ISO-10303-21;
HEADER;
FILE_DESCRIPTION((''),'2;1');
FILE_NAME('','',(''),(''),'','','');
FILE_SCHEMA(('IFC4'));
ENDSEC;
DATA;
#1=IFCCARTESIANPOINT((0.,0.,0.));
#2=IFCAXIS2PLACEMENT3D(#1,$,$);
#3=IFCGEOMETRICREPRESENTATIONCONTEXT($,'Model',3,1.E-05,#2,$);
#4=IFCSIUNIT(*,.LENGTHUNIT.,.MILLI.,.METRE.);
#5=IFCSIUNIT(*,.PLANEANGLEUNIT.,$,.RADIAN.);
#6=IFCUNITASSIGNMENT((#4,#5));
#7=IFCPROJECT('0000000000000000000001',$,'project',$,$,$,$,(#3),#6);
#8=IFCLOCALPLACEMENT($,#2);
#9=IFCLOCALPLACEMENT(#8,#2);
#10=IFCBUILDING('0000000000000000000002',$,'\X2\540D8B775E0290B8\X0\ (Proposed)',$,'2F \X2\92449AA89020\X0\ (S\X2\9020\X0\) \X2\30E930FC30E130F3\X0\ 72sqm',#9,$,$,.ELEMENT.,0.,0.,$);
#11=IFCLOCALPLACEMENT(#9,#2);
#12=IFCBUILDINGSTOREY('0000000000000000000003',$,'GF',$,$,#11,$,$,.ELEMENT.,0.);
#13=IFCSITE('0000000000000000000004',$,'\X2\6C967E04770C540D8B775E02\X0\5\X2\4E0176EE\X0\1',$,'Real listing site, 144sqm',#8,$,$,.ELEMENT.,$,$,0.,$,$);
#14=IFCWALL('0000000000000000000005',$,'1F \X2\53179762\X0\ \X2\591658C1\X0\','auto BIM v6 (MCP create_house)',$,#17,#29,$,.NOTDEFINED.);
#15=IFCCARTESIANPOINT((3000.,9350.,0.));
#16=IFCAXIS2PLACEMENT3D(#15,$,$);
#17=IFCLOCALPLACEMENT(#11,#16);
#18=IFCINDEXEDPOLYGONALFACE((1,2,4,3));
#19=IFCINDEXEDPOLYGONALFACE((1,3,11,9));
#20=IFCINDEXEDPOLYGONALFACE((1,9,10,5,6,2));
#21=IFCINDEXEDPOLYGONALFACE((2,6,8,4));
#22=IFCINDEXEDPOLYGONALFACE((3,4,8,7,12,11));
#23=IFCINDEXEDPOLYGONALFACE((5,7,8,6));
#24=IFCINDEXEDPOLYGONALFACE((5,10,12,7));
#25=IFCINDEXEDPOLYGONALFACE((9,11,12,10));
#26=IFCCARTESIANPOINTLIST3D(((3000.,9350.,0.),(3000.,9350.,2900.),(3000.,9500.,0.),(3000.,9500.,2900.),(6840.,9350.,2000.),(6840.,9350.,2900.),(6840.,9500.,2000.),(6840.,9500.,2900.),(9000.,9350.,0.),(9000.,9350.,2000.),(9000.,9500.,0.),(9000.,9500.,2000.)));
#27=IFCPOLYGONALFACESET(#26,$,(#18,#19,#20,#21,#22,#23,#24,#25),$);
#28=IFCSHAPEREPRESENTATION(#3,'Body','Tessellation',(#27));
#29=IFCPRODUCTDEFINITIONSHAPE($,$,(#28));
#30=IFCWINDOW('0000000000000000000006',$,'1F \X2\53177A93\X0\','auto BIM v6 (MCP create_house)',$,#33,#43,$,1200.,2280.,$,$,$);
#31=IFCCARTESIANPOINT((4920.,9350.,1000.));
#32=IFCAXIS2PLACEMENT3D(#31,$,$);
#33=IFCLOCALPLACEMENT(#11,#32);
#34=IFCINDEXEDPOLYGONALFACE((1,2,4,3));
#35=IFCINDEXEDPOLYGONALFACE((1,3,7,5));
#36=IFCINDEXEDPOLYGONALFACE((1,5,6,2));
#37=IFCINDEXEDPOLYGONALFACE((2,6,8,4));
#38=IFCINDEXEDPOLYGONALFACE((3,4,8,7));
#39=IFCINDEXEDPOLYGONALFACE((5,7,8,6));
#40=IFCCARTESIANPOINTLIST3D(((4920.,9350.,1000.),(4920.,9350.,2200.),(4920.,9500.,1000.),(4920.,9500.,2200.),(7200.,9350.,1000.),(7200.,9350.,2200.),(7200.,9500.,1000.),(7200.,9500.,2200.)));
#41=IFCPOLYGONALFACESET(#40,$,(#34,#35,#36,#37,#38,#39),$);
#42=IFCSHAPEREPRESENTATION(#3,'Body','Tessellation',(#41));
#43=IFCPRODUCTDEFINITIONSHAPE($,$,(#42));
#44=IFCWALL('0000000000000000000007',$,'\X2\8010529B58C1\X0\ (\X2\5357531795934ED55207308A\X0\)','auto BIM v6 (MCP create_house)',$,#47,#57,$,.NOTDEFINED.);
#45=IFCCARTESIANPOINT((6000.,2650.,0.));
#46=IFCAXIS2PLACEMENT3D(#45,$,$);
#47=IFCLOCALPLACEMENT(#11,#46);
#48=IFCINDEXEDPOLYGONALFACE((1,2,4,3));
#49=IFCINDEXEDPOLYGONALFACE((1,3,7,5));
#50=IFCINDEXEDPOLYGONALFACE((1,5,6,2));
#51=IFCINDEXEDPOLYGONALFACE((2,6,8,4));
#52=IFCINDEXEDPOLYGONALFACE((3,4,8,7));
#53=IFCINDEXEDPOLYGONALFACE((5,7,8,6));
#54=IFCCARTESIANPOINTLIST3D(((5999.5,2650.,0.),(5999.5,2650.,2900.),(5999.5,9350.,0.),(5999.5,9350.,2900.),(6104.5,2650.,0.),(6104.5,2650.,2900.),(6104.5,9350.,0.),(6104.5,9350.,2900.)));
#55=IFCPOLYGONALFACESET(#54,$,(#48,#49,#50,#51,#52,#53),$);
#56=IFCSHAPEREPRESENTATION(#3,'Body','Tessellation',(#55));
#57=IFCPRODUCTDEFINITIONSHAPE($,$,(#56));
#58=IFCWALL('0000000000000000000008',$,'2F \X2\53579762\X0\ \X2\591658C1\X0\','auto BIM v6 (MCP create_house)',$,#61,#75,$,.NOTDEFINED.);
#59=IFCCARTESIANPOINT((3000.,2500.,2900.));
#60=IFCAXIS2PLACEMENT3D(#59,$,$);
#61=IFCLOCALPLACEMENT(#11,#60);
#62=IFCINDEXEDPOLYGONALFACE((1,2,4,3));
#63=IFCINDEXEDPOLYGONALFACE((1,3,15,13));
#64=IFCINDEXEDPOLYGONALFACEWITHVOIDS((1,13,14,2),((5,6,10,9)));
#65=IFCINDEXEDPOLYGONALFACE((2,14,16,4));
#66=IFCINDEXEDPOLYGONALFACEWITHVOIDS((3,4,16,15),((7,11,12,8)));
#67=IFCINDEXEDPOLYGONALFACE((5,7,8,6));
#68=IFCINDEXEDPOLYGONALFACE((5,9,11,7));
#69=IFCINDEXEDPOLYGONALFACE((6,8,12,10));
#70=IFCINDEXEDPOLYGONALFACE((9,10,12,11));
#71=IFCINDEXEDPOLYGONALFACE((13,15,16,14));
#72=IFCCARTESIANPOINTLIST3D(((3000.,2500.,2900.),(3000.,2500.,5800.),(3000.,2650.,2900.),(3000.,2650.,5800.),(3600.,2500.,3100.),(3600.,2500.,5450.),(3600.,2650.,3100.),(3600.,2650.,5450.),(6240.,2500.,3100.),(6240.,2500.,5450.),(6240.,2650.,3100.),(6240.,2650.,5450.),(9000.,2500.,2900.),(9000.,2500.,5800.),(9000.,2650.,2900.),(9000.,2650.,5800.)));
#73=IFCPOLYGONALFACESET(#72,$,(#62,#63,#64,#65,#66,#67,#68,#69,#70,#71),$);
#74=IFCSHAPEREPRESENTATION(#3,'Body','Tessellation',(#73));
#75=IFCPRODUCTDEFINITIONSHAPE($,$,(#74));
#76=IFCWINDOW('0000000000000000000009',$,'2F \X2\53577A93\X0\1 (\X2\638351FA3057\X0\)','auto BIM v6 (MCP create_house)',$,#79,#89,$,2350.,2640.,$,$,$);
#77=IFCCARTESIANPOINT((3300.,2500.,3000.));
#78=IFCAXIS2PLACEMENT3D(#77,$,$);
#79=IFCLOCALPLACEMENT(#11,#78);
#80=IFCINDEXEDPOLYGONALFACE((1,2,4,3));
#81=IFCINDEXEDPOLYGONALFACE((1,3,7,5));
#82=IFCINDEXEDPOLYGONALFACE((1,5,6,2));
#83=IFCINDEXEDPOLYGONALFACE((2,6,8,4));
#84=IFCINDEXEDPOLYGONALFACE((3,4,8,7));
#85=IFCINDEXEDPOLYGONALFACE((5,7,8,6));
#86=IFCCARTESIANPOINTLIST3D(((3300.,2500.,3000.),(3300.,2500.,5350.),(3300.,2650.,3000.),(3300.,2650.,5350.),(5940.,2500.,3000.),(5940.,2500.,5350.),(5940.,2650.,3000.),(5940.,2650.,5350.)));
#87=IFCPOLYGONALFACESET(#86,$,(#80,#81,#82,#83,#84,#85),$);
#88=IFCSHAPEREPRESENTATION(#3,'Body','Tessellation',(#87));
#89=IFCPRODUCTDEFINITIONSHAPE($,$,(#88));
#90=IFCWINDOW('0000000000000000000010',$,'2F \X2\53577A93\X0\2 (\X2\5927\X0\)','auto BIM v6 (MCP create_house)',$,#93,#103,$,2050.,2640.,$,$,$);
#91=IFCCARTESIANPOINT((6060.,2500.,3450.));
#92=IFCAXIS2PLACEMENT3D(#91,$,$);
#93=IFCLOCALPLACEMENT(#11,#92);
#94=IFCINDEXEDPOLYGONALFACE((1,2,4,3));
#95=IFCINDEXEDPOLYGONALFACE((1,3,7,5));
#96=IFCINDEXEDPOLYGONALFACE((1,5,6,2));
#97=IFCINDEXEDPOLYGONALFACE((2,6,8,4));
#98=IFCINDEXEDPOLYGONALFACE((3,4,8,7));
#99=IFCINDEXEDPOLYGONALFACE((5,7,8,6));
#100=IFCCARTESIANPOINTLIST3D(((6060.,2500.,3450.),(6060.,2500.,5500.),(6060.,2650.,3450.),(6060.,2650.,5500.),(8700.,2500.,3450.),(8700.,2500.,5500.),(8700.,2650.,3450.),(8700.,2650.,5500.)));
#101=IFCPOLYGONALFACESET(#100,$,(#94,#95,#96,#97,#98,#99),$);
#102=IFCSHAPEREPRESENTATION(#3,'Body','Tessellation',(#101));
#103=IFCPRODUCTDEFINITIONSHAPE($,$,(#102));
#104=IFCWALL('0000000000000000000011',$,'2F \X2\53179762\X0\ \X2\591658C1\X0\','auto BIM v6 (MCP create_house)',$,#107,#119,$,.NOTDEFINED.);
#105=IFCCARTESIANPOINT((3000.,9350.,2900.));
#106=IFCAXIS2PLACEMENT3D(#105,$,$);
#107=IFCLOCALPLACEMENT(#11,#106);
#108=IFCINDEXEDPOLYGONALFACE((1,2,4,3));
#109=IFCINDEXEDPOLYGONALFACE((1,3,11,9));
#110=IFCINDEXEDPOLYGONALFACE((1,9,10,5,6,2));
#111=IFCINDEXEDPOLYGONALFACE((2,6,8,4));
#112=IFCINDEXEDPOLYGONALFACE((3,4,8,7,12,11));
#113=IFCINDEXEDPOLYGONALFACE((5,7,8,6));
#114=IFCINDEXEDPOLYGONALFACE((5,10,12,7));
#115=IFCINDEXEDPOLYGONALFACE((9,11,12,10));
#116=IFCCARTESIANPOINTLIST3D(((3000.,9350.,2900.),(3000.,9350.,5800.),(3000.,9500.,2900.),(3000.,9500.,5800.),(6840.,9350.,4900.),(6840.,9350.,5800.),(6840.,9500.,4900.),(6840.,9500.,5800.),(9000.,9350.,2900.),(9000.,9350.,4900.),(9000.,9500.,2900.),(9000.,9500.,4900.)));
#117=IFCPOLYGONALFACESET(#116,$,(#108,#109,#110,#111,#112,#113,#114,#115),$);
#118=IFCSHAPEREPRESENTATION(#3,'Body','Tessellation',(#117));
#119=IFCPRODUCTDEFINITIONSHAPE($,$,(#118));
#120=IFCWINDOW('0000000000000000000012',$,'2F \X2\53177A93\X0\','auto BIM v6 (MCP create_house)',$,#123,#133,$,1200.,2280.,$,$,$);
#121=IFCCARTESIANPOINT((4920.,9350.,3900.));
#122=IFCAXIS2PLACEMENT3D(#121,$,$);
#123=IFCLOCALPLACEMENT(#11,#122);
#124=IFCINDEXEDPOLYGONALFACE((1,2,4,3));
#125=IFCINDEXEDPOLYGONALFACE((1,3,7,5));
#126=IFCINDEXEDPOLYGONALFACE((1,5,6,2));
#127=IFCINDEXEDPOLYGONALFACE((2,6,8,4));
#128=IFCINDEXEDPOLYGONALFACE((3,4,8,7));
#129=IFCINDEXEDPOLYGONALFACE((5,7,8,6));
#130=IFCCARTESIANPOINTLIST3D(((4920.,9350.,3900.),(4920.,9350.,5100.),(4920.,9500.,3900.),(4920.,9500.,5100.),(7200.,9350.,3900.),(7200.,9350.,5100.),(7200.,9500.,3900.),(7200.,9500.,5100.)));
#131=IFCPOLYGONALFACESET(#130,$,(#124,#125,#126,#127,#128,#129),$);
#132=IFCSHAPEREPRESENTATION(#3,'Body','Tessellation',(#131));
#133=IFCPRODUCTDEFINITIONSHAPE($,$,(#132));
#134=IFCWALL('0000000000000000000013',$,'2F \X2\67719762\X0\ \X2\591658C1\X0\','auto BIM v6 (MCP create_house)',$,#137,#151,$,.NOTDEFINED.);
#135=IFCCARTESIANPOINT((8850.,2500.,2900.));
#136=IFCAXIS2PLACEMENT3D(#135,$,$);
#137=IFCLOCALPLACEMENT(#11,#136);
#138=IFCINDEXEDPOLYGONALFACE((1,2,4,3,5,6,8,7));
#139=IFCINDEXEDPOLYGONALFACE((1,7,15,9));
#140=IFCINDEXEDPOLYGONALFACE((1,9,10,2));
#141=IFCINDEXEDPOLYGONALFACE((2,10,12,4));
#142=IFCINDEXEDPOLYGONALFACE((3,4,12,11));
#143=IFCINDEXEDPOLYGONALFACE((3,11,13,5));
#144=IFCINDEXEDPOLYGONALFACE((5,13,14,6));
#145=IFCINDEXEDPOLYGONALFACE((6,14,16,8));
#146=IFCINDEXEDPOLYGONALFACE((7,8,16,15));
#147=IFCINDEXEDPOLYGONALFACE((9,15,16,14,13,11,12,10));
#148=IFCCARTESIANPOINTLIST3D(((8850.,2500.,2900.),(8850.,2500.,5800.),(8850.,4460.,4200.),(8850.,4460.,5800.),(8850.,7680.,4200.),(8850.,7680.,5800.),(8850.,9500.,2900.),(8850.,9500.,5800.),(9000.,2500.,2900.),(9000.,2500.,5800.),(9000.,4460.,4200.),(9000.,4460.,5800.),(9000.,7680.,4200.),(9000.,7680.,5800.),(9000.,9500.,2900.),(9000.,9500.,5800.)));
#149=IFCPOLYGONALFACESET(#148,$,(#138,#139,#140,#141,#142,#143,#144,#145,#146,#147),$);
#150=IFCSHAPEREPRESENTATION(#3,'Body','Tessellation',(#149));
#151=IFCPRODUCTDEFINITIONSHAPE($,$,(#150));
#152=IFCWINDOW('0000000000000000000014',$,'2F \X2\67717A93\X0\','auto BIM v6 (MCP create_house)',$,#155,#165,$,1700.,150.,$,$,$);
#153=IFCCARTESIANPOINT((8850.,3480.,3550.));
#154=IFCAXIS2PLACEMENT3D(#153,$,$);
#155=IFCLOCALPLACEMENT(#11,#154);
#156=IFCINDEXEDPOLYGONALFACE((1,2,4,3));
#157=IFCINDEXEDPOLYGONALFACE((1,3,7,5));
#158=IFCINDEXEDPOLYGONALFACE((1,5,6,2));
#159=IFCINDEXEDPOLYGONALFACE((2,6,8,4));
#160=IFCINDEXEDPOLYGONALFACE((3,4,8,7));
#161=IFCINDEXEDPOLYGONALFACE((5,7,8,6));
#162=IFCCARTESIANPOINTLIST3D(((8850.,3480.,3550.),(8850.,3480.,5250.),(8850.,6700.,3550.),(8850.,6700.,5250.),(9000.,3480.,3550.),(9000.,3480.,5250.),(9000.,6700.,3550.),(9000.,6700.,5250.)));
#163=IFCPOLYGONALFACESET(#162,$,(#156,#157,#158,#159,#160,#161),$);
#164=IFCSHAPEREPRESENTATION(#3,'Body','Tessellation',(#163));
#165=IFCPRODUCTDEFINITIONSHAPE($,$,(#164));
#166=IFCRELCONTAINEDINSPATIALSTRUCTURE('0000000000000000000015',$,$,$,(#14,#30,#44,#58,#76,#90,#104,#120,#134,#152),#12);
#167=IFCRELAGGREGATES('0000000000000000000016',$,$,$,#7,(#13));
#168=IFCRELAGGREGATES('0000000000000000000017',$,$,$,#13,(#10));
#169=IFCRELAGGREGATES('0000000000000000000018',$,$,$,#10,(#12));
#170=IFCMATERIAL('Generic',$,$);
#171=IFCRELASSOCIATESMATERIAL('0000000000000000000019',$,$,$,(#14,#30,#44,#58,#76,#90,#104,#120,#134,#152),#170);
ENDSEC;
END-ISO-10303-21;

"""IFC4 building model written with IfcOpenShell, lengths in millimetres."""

from ifc_helpers import new_model, si_unit, frame, frame_2d, origin, place, context, project, spatial, rectangle, extrude, material, element, fill, save


model = new_model("IFC4")

# Units and contexts
model_context = context("Model", 3, precision=1e-05, world=origin())
ifc_project = project(units=[si_unit("LENGTHUNIT", "METRE", prefix="MILLI"), si_unit("PLANEANGLEUNIT", "RADIAN")], contexts=[model_context])

# Site, building, storey
site_placement = place(None, origin())
site = spatial("IfcSite", under=ifc_project, at=site_placement, Name="沖縄県名護市5丁目1", ObjectType="Real listing site, 144sqm", CompositionType="ELEMENT", RefElevation=0.0)
building_placement = place(site_placement, origin())
building = spatial("IfcBuilding", under=site, at=building_placement, Name="名護市邸 (Proposed)", ObjectType="2F 鉄骨造 (S造) ラーメン 72sqm", CompositionType="ELEMENT", ElevationOfRefHeight=0.0, ElevationOfTerrain=0.0)
storey_placement = place(building_placement, origin())
storey = spatial("IfcBuildingStorey", under=building, at=storey_placement, Name="GF", CompositionType="ELEMENT", Elevation=0.0)

# Wall, opening, window
ifc_material = material(Name="Generic")
wall_1_placement = place(storey_placement, frame((3000.0, 9350.0, 0.0)))
wall_1 = element("IfcWall", 1, at=wall_1_placement, inside=storey, material=ifc_material, Name="1F 北面 外壁", Description="auto BIM v6 (MCP create_house)", PredefinedType="NOTDEFINED", context=model_context, shape_type="SweptSolid", body=[
    extrude(rectangle(XDim=6000.0, YDim=150.0, at=frame_2d((3000.0, 75.0))), frame((3000.0, 9350.0, 0.0)), (0.0, 0.0, 1.0), 2900.0),
])
opening_1_placement = place(storey_placement, frame((4920.0, 9350.0, 1000.0)))
opening_1 = element("IfcOpeningElement", 2, at=opening_1_placement, cuts=wall_1, PredefinedType="NOTDEFINED", context=model_context, shape_type="SweptSolid", body=[
    extrude(rectangle(XDim=2280.0, YDim=150.0, at=frame_2d((1140.0, 75.0))), frame((4920.0, 9350.0, 1000.0)), (0.0, 0.0, 1.0), 1200.0),
])
window_1_placement = place(storey_placement, frame((4920.0, 9350.0, 1000.0)))
window_1 = element("IfcWindow", 3, at=window_1_placement, inside=storey, material=ifc_material, Name="1F 北窓", Description="auto BIM v6 (MCP create_house)", OverallHeight=1200.0, OverallWidth=2280.0, context=model_context, shape_type="SweptSolid", body=[
    extrude(rectangle(XDim=2280.0, YDim=150.0, at=frame_2d((1140.0, 75.0))), frame((4920.0, 9350.0, 1000.0)), (0.0, 0.0, 1.0), 1200.0),
])
fill(opening_1, window_1)

# Wall
wall_2_placement = place(storey_placement, frame((6000.0, 2650.0, 0.0)))
element("IfcWall", 4, at=wall_2_placement, inside=storey, material=ifc_material, Name="耐力壁 (南北間仕切り)", Description="auto BIM v6 (MCP create_house)", PredefinedType="NOTDEFINED", context=model_context, shape_type="SweptSolid", body=[
    extrude(rectangle(XDim=105.0, YDim=6700.0, at=frame_2d((52.0, 3350.0))), frame((6000.0, 2650.0, 0.0)), (0.0, 0.0, 1.0), 2900.0),
])

# Wall, openings, windows
wall_3_placement = place(storey_placement, frame((3000.0, 2500.0, 2900.0)))
wall_3 = element("IfcWall", 5, at=wall_3_placement, inside=storey, material=ifc_material, Name="2F 南面 外壁", Description="auto BIM v6 (MCP create_house)", PredefinedType="NOTDEFINED", context=model_context, shape_type="SweptSolid", body=[
    extrude(rectangle(XDim=6000.0, YDim=150.0, at=frame_2d((3000.0, 75.0))), frame((3000.0, 2500.0, 2900.0)), (0.0, 0.0, 1.0), 2900.0),
])
opening_2_placement = place(storey_placement, frame((3300.0, 2500.0, 3000.0)))
opening_2 = element("IfcOpeningElement", 6, at=opening_2_placement, cuts=wall_3, PredefinedType="NOTDEFINED", context=model_context, shape_type="SweptSolid", body=[
    extrude(rectangle(XDim=2640.0, YDim=150.0, at=frame_2d((1320.0, 75.0))), frame((3300.0, 2500.0, 3000.0)), (0.0, 0.0, 1.0), 2350.0),
])
opening_3_placement = place(storey_placement, frame((6060.0, 2500.0, 3450.0)))
opening_3 = element("IfcOpeningElement", 7, at=opening_3_placement, cuts=wall_3, PredefinedType="NOTDEFINED", context=model_context, shape_type="SweptSolid", body=[
    extrude(rectangle(XDim=2640.0, YDim=150.0, at=frame_2d((1320.0, 75.0))), frame((6060.0, 2500.0, 3450.0)), (0.0, 0.0, 1.0), 2050.0),
])
window_2_placement = place(storey_placement, frame((3300.0, 2500.0, 3000.0)))
window_2 = element("IfcWindow", 8, at=window_2_placement, inside=storey, material=ifc_material, Name="2F 南窓1 (掃出し)", Description="auto BIM v6 (MCP create_house)", OverallHeight=2350.0, OverallWidth=2640.0, context=model_context, shape_type="SweptSolid", body=[
    extrude(rectangle(XDim=2640.0, YDim=150.0, at=frame_2d((1320.0, 75.0))), frame((3300.0, 2500.0, 3000.0)), (0.0, 0.0, 1.0), 2350.0),
])
fill(opening_2, window_2)
window_3_placement = place(storey_placement, frame((6060.0, 2500.0, 3450.0)))
window_3 = element("IfcWindow", 9, at=window_3_placement, inside=storey, material=ifc_material, Name="2F 南窓2 (大)", Description="auto BIM v6 (MCP create_house)", OverallHeight=2050.0, OverallWidth=2640.0, context=model_context, shape_type="SweptSolid", body=[
    extrude(rectangle(XDim=2640.0, YDim=150.0, at=frame_2d((1320.0, 75.0))), frame((6060.0, 2500.0, 3450.0)), (0.0, 0.0, 1.0), 2050.0),
])
fill(opening_3, window_3)

# Walls, openings, windows
wall_4_placement = place(storey_placement, frame((3000.0, 9350.0, 2900.0)))
wall_4 = element("IfcWall", 10, at=wall_4_placement, inside=storey, material=ifc_material, Name="2F 北面 外壁", Description="auto BIM v6 (MCP create_house)", PredefinedType="NOTDEFINED", context=model_context, shape_type="SweptSolid", body=[
    extrude(rectangle(XDim=6000.0, YDim=150.0, at=frame_2d((3000.0, 75.0))), frame((3000.0, 9350.0, 2900.0)), (0.0, 0.0, 1.0), 2900.0),
])
opening_4_placement = place(storey_placement, frame((4920.0, 9350.0, 3900.0)))
opening_4 = element("IfcOpeningElement", 11, at=opening_4_placement, cuts=wall_4, PredefinedType="NOTDEFINED", context=model_context, shape_type="SweptSolid", body=[
    extrude(rectangle(XDim=2280.0, YDim=150.0, at=frame_2d((1140.0, 75.0))), frame((4920.0, 9350.0, 3900.0)), (0.0, 0.0, 1.0), 1200.0),
])
window_4_placement = place(storey_placement, frame((4920.0, 9350.0, 3900.0)))
window_4 = element("IfcWindow", 12, at=window_4_placement, inside=storey, material=ifc_material, Name="2F 北窓", Description="auto BIM v6 (MCP create_house)", OverallHeight=1200.0, OverallWidth=2280.0, context=model_context, shape_type="SweptSolid", body=[
    extrude(rectangle(XDim=2280.0, YDim=150.0, at=frame_2d((1140.0, 75.0))), frame((4920.0, 9350.0, 3900.0)), (0.0, 0.0, 1.0), 1200.0),
])
fill(opening_4, window_4)
wall_5_placement = place(storey_placement, frame((8850.0, 2500.0, 2900.0)))
wall_5 = element("IfcWall", 13, at=wall_5_placement, inside=storey, material=ifc_material, Name="2F 東面 外壁", Description="auto BIM v6 (MCP create_house)", PredefinedType="NOTDEFINED", context=model_context, shape_type="SweptSolid", body=[
    extrude(rectangle(XDim=150.0, YDim=7000.0, at=frame_2d((75.0, 3500.0))), frame((8850.0, 2500.0, 2900.0)), (0.0, 0.0, 1.0), 2900.0),
])
opening_5_placement = place(storey_placement, frame((8850.0, 3480.0, 3550.0)))
opening_5 = element("IfcOpeningElement", 14, at=opening_5_placement, cuts=wall_5, PredefinedType="NOTDEFINED", context=model_context, shape_type="SweptSolid", body=[
    extrude(rectangle(XDim=150.0, YDim=3220.0, at=frame_2d((75.0, 1610.0))), frame((8850.0, 3480.0, 3550.0)), (0.0, 0.0, 1.0), 1700.0),
])
window_5_placement = place(storey_placement, frame((8850.0, 3480.0, 3550.0)))
window_5 = element("IfcWindow", 15, at=window_5_placement, inside=storey, material=ifc_material, Name="2F 東窓", Description="auto BIM v6 (MCP create_house)", OverallHeight=1700.0, OverallWidth=150.0, context=model_context, shape_type="SweptSolid", body=[
    extrude(rectangle(XDim=150.0, YDim=3220.0, at=frame_2d((75.0, 1610.0))), frame((8850.0, 3480.0, 3550.0)), (0.0, 0.0, 1.0), 1700.0),
])
fill(opening_5, window_5)

save(model, "model.ifc")
